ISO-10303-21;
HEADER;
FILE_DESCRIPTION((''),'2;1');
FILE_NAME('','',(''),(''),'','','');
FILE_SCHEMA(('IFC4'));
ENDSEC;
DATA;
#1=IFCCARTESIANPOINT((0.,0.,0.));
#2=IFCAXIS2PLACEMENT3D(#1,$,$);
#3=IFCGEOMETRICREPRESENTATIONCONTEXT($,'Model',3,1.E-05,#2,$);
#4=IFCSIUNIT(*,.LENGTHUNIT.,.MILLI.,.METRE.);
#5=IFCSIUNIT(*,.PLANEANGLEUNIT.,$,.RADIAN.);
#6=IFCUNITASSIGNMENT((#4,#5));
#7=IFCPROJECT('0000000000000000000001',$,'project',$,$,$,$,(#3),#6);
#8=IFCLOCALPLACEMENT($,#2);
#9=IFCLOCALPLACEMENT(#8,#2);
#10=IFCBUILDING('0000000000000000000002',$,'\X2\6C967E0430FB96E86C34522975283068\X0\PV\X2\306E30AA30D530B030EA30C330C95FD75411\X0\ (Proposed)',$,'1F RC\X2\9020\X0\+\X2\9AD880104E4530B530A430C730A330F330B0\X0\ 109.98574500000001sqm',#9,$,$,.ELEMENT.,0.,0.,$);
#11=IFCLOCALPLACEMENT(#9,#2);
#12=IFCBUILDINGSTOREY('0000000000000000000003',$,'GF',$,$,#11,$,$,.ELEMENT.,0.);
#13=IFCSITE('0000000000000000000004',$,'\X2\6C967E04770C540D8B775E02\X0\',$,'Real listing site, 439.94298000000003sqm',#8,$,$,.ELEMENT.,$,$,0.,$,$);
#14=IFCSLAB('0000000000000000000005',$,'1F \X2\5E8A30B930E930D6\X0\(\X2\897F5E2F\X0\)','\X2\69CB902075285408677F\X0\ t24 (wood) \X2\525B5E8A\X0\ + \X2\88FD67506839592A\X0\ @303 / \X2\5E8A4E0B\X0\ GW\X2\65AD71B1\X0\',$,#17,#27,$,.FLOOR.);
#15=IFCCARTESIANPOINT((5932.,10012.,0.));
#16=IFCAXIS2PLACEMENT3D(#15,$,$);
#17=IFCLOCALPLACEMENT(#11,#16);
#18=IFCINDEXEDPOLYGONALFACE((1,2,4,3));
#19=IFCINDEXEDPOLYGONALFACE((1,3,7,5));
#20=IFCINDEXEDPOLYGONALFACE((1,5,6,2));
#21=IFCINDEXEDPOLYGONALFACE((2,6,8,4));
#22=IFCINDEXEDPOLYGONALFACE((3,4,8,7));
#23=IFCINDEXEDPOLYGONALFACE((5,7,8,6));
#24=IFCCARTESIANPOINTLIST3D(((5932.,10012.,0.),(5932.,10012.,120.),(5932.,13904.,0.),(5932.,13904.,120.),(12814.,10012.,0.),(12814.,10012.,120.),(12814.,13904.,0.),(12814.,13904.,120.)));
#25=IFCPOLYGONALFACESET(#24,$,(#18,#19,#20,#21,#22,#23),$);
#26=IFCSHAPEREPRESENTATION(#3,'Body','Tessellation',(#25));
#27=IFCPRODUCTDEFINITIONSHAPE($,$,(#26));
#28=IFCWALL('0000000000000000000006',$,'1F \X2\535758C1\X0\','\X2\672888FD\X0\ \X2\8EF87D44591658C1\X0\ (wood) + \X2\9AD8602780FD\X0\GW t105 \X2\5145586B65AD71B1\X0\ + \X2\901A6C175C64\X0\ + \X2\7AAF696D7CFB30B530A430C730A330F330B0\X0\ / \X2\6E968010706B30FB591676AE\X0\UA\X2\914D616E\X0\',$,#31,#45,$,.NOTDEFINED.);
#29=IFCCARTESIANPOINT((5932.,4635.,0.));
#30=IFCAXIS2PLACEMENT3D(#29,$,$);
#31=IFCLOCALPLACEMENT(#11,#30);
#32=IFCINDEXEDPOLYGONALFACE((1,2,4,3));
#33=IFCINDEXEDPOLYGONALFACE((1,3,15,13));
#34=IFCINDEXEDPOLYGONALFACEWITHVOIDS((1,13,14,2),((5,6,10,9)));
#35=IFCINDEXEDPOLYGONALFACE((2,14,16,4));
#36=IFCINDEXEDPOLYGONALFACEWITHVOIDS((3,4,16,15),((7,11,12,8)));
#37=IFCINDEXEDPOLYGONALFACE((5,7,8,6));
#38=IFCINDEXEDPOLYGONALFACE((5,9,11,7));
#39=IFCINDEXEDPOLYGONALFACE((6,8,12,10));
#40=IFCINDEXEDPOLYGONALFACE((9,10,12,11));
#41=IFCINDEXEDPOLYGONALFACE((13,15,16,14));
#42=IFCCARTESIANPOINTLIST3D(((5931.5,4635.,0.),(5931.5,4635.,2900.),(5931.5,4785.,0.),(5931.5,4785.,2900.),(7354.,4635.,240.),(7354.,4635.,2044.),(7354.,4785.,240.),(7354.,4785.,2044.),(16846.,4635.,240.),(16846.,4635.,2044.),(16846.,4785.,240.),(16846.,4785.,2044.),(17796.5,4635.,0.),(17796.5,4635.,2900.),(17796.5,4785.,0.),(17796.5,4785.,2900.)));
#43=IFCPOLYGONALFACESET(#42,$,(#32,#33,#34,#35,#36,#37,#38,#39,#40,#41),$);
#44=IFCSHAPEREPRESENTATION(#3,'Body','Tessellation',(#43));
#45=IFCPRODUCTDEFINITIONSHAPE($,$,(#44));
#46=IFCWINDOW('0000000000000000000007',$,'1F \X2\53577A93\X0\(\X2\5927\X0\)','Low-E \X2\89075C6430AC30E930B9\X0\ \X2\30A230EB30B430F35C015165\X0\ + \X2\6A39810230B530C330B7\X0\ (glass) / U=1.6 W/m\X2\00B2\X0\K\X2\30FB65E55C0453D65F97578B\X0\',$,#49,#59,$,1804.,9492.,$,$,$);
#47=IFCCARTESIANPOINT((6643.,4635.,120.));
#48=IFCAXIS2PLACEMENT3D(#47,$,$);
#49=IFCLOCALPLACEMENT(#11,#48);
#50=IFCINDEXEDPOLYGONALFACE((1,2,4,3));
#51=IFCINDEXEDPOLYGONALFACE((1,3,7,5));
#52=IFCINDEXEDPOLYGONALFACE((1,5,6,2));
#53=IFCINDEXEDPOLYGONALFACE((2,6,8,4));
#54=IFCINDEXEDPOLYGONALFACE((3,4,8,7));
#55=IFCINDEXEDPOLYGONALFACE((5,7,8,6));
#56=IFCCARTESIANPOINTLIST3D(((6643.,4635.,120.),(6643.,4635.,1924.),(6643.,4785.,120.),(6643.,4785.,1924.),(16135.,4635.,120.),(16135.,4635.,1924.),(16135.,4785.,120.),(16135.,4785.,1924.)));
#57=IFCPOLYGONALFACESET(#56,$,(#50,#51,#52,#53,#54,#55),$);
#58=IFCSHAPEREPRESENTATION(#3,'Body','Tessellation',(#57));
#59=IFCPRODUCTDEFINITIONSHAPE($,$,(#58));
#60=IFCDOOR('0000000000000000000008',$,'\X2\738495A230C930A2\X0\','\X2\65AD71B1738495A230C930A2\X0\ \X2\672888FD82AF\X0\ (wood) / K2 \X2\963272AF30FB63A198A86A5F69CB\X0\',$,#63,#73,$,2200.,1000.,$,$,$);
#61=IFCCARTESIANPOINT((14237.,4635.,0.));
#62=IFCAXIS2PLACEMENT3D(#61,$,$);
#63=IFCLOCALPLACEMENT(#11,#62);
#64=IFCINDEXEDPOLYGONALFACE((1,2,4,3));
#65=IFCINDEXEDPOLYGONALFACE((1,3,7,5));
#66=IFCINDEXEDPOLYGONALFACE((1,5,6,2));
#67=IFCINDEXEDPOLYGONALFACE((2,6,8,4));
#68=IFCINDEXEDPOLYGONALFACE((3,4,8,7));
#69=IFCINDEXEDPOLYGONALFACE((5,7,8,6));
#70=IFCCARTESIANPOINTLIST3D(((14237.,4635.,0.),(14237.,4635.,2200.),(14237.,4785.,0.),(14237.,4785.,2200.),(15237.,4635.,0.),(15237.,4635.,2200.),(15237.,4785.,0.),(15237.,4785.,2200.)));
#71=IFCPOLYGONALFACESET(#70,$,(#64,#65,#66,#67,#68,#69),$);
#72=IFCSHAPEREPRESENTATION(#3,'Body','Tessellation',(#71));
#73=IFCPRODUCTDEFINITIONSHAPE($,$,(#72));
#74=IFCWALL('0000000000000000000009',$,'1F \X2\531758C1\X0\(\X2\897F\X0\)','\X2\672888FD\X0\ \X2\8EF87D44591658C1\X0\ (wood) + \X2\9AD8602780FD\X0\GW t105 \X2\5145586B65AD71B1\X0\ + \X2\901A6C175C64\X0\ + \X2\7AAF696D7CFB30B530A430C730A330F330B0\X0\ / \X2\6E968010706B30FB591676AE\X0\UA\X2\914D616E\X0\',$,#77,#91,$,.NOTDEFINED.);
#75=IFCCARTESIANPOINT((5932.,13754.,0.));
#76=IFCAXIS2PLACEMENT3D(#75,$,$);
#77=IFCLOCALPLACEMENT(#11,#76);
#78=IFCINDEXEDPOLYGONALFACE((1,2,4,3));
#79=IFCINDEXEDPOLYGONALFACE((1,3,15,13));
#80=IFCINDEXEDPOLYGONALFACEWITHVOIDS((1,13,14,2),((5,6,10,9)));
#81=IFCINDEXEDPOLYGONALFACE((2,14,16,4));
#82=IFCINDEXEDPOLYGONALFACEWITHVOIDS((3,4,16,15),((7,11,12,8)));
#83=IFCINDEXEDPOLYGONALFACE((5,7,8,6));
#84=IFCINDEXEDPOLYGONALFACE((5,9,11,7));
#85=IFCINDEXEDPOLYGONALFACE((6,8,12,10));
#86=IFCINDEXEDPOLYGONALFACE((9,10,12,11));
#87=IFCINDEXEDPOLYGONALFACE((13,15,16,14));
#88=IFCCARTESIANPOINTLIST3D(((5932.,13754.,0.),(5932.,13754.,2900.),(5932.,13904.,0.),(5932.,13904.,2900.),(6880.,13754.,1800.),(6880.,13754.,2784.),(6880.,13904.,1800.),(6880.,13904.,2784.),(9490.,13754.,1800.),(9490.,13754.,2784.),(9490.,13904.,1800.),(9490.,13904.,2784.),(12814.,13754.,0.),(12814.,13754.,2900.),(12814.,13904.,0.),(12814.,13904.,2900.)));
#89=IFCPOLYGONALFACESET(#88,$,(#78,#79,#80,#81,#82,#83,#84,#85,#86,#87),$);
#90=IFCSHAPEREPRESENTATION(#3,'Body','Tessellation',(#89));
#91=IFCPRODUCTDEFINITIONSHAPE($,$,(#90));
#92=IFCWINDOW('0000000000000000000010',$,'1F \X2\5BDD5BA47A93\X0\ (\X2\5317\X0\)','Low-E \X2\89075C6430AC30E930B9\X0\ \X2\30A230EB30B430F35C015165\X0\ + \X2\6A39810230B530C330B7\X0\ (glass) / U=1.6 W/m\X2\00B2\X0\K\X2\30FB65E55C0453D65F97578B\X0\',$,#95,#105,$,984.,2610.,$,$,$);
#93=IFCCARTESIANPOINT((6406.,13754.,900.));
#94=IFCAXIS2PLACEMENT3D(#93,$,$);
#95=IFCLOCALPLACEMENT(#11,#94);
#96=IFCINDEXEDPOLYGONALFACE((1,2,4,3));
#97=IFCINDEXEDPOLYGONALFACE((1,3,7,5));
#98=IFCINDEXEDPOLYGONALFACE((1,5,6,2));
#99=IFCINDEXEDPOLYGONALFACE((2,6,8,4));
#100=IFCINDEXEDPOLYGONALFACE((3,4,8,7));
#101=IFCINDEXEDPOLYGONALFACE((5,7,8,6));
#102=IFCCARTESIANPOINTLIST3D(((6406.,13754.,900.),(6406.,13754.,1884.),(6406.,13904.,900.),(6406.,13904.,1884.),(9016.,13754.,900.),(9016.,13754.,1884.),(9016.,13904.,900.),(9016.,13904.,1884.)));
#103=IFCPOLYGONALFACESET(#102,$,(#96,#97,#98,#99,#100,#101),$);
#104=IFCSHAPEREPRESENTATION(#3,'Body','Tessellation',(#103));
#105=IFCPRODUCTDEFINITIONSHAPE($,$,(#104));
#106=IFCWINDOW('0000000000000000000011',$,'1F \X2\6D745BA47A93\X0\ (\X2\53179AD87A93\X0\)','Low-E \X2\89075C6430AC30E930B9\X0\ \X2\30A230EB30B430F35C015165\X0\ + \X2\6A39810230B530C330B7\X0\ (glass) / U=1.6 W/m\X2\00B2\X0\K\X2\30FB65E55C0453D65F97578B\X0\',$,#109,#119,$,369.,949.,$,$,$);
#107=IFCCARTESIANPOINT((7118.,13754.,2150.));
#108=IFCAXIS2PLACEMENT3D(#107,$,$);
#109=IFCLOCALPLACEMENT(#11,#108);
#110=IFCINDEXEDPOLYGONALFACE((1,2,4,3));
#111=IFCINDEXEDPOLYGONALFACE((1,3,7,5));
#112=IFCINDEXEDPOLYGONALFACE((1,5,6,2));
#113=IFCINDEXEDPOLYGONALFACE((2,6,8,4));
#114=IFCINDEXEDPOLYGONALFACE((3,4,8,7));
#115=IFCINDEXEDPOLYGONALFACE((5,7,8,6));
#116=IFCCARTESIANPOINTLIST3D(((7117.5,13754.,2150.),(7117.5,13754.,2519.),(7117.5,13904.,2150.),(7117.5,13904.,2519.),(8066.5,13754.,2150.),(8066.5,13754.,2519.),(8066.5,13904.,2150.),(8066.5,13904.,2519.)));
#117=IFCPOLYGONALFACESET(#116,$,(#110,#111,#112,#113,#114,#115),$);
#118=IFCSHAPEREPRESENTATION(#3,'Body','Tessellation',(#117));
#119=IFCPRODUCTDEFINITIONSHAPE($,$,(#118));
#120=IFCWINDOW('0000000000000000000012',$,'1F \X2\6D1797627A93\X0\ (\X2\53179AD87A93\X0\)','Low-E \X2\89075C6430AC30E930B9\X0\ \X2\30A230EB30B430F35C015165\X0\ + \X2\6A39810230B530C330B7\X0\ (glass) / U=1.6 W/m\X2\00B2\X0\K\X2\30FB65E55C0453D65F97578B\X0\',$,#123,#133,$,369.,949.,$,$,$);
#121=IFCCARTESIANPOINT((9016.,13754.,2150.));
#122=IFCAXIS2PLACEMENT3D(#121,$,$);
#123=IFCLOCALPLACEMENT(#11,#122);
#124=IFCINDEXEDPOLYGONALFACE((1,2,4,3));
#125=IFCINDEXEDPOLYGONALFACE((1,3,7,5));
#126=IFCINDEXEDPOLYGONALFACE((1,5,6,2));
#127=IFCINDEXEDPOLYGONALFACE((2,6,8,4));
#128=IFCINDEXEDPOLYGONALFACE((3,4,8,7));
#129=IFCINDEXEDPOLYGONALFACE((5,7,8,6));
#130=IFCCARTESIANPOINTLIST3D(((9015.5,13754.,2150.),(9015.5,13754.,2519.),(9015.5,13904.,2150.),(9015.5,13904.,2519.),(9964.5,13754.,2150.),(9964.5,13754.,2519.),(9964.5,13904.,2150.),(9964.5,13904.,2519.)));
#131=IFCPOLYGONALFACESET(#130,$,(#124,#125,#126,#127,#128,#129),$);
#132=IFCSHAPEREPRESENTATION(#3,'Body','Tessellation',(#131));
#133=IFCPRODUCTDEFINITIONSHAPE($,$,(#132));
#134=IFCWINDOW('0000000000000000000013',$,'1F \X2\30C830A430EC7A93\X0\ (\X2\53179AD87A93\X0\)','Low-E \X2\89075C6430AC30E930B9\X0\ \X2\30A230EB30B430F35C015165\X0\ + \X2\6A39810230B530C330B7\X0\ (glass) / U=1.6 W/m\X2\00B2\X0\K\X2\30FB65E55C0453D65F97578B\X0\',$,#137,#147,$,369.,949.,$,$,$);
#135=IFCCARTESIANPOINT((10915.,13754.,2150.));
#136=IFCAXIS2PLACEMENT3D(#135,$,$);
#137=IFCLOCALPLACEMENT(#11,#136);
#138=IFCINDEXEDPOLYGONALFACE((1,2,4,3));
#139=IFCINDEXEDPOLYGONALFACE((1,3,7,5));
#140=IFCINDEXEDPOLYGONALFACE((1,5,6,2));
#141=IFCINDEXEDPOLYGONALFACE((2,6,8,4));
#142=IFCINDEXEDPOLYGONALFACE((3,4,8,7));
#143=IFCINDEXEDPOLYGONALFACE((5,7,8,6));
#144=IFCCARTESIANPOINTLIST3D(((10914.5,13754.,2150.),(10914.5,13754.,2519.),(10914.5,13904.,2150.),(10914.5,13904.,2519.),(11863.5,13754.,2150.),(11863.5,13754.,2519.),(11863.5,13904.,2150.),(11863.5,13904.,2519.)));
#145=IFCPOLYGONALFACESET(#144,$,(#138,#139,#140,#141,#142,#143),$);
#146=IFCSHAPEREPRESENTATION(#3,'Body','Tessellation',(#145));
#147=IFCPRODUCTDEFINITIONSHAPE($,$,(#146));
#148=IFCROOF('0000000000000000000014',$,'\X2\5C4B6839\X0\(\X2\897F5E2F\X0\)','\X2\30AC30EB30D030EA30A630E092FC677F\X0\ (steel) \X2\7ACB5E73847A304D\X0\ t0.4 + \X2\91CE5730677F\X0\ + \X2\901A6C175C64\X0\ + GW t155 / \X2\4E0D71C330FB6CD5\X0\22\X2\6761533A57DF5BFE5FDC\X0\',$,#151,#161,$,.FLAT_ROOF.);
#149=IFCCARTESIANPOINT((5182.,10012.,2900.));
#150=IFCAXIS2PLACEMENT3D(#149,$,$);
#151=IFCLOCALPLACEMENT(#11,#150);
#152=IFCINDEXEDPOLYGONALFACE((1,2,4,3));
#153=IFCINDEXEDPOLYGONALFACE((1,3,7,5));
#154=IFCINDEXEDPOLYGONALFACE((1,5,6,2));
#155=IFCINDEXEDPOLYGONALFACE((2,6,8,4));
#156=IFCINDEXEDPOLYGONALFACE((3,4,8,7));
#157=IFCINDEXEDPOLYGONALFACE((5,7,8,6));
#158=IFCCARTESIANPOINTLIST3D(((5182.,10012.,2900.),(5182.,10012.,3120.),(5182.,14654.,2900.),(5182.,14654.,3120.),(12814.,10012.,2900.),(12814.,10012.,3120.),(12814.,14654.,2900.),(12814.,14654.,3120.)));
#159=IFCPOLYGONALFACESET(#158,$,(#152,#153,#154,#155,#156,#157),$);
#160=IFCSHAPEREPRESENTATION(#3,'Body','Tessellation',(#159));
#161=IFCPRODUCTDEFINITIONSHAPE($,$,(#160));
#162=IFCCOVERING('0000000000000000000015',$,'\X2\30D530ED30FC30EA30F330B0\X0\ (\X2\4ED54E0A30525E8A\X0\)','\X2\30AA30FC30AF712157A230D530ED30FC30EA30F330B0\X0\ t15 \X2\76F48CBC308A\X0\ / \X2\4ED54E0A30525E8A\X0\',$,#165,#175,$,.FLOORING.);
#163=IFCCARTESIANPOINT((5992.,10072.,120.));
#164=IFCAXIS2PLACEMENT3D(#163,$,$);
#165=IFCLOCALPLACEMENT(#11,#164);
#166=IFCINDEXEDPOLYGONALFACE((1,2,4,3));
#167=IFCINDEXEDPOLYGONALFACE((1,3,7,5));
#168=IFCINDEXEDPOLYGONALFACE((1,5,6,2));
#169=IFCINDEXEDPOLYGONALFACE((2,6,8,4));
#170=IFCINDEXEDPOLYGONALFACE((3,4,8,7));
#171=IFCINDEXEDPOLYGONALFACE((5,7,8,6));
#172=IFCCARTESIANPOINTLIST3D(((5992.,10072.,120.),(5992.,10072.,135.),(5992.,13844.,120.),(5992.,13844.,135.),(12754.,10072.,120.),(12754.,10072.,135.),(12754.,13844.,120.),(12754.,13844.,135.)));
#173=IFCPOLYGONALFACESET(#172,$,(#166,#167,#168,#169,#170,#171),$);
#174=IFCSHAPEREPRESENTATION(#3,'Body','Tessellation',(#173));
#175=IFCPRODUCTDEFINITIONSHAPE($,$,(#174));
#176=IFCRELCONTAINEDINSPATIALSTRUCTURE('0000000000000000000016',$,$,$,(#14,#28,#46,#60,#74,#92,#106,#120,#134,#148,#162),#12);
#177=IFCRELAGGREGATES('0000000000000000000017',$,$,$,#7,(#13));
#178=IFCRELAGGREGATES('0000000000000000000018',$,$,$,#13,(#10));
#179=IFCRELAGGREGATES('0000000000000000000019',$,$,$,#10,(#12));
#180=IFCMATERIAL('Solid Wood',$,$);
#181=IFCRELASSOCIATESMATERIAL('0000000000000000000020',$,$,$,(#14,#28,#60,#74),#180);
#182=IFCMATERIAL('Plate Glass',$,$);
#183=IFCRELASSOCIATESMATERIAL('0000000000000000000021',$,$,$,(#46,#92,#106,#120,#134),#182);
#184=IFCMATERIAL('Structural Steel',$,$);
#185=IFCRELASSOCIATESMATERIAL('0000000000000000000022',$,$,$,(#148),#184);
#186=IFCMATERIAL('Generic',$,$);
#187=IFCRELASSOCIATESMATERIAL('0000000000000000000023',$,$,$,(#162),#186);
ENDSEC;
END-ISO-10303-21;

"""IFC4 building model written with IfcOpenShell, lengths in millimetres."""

from ifc_helpers import new_model, si_unit, frame, frame_2d, origin, place, context, project, spatial, rectangle, extrude, material, element, fill, save


model = new_model("IFC4")

# Units and contexts
model_context = context("Model", 3, precision=1e-05, world=origin())
ifc_project = project(units=[si_unit("LENGTHUNIT", "METRE", prefix="MILLI"), si_unit("PLANEANGLEUNIT", "RADIAN")], contexts=[model_context])

# Site, building, storey
site_placement = place(None, origin())
site = spatial("IfcSite", under=ifc_project, at=site_placement, Name="沖縄県名護市", ObjectType="Real listing site, 439.94298000000003sqm", CompositionType="ELEMENT", RefElevation=0.0)
building_placement = place(site_placement, origin())
building = spatial("IfcBuilding", under=site, at=building_placement, Name="沖縄・雨水利用とPVのオフグリッド志向 (Proposed)", ObjectType="1F RC造+高耐久サイディング 109.98574500000001sqm", CompositionType="ELEMENT", ElevationOfRefHeight=0.0, ElevationOfTerrain=0.0)
storey_placement = place(building_placement, origin())
storey = spatial("IfcBuildingStorey", under=building, at=storey_placement, Name="GF", CompositionType="ELEMENT", Elevation=0.0)

# Slab
ifc_material_1 = material(Name="Solid Wood")
slab_1_placement = place(storey_placement, frame((5932.0, 10012.0, 0.0)))
element("IfcSlab", 1, at=slab_1_placement, inside=storey, material=ifc_material_1, Name="1F 床スラブ(西帯)", Description="構造用合板 t24 (wood) 剛床 + 製材根太 @303 / 床下 GW断熱", PredefinedType="FLOOR", context=model_context, shape_type="SweptSolid", body=[
    extrude(rectangle(XDim=6882.0, YDim=3892.0, at=frame_2d((3441.0, 1946.0))), frame((5932.0, 10012.0, 0.0)), (0.0, 0.0, 1.0), 120.0),
])

# Wall, openings, window, door
wall_1_placement = place(storey_placement, frame((5932.0, 4635.0, 0.0)))
wall_1 = element("IfcWall", 2, at=wall_1_placement, inside=storey, material=ifc_material_1, Name="1F 南壁", Description="木製 軸組外壁 (wood) + 高性能GW t105 充填断熱 + 通気層 + 窯業系サイディング / 準耐火・外皮UA配慮", PredefinedType="NOTDEFINED", context=model_context, shape_type="SweptSolid", body=[
    extrude(rectangle(XDim=11865.0, YDim=150.0, at=frame_2d((5932.0, 75.0))), frame((5932.0, 4635.0, 0.0)), (0.0, 0.0, 1.0), 2900.0),
])
opening_1_placement = place(storey_placement, frame((6643.0, 4635.0, 120.0)))
opening_1 = element("IfcOpeningElement", 3, at=opening_1_placement, cuts=wall_1, PredefinedType="NOTDEFINED", context=model_context, shape_type="SweptSolid", body=[
    extrude(rectangle(XDim=9492.0, YDim=150.0, at=frame_2d((4746.0, 75.0))), frame((6643.0, 4635.0, 120.0)), (0.0, 0.0, 1.0), 1804.0),
])
opening_2_placement = place(storey_placement, frame((14237.0, 4635.0, 0.0)))
opening_2 = element("IfcOpeningElement", 4, at=opening_2_placement, cuts=wall_1, PredefinedType="NOTDEFINED", context=model_context, shape_type="SweptSolid", body=[
    extrude(rectangle(XDim=1000.0, YDim=150.0, at=frame_2d((500.0, 75.0))), frame((14237.0, 4635.0, 0.0)), (0.0, 0.0, 1.0), 2200.0),
])
ifc_material_2 = material(Name="Plate Glass")
window_1_placement = place(storey_placement, frame((6643.0, 4635.0, 120.0)))
window_1 = element("IfcWindow", 5, at=window_1_placement, inside=storey, material=ifc_material_2, Name="1F 南窓(大)", Description="Low-E 複層ガラス アルゴン封入 + 樹脂サッシ (glass) / U=1.6 W/m²K・日射取得型", OverallHeight=1804.0, OverallWidth=9492.0, context=model_context, shape_type="SweptSolid", body=[
    extrude(rectangle(XDim=9492.0, YDim=150.0, at=frame_2d((4746.0, 75.0))), frame((6643.0, 4635.0, 120.0)), (0.0, 0.0, 1.0), 1804.0),
])
fill(opening_1, window_1)
door_1_placement = place(storey_placement, frame((14237.0, 4635.0, 0.0)))
door_1 = element("IfcDoor", 6, at=door_1_placement, inside=storey, material=ifc_material_1, Name="玄関ドア", Description="断熱玄関ドア 木製芯 (wood) / K2 防犯・採風機構", OverallHeight=2200.0, OverallWidth=1000.0, context=model_context, shape_type="SweptSolid", body=[
    extrude(rectangle(XDim=1000.0, YDim=150.0, at=frame_2d((500.0, 75.0))), frame((14237.0, 4635.0, 0.0)), (0.0, 0.0, 1.0), 2200.0),
])
fill(opening_2, door_1)

# Wall, openings, windows
wall_2_placement = place(storey_placement, frame((5932.0, 13754.0, 0.0)))
wall_2 = element("IfcWall", 7, at=wall_2_placement, inside=storey, material=ifc_material_1, Name="1F 北壁(西)", Description="木製 軸組外壁 (wood) + 高性能GW t105 充填断熱 + 通気層 + 窯業系サイディング / 準耐火・外皮UA配慮", PredefinedType="NOTDEFINED", context=model_context, shape_type="SweptSolid", body=[
    extrude(rectangle(XDim=6882.0, YDim=150.0, at=frame_2d((3441.0, 75.0))), frame((5932.0, 13754.0, 0.0)), (0.0, 0.0, 1.0), 2900.0),
])
opening_3_placement = place(storey_placement, frame((6406.0, 13754.0, 900.0)))
opening_3 = element("IfcOpeningElement", 8, at=opening_3_placement, cuts=wall_2, PredefinedType="NOTDEFINED", context=model_context, shape_type="SweptSolid", body=[
    extrude(rectangle(XDim=2610.0, YDim=150.0, at=frame_2d((1305.0, 75.0))), frame((6406.0, 13754.0, 900.0)), (0.0, 0.0, 1.0), 984.0),
])
opening_4_placement = place(storey_placement, frame((7118.0, 13754.0, 2150.0)))
opening_4 = element("IfcOpeningElement", 9, at=opening_4_placement, cuts=wall_2, PredefinedType="NOTDEFINED", context=model_context, shape_type="SweptSolid", body=[
    extrude(rectangle(XDim=949.0, YDim=150.0, at=frame_2d((474.0, 75.0))), frame((7118.0, 13754.0, 2150.0)), (0.0, 0.0, 1.0), 369.0),
])
opening_5_placement = place(storey_placement, frame((9016.0, 13754.0, 2150.0)))
opening_5 = element("IfcOpeningElement", 10, at=opening_5_placement, cuts=wall_2, PredefinedType="NOTDEFINED", context=model_context, shape_type="SweptSolid", body=[
    extrude(rectangle(XDim=949.0, YDim=150.0, at=frame_2d((474.0, 75.0))), frame((9016.0, 13754.0, 2150.0)), (0.0, 0.0, 1.0), 369.0),
])
opening_6_placement = place(storey_placement, frame((10915.0, 13754.0, 2150.0)))
opening_6 = element("IfcOpeningElement", 11, at=opening_6_placement, cuts=wall_2, PredefinedType="NOTDEFINED", context=model_context, shape_type="SweptSolid", body=[
    extrude(rectangle(XDim=949.0, YDim=150.0, at=frame_2d((474.0, 75.0))), frame((10915.0, 13754.0, 2150.0)), (0.0, 0.0, 1.0), 369.0),
])
window_2_placement = place(storey_placement, frame((6406.0, 13754.0, 900.0)))
window_2 = element("IfcWindow", 12, at=window_2_placement, inside=storey, material=ifc_material_2, Name="1F 寝室窓 (北)", Description="Low-E 複層ガラス アルゴン封入 + 樹脂サッシ (glass) / U=1.6 W/m²K・日射取得型", OverallHeight=984.0, OverallWidth=2610.0, context=model_context, shape_type="SweptSolid", body=[
    extrude(rectangle(XDim=2610.0, YDim=150.0, at=frame_2d((1305.0, 75.0))), frame((6406.0, 13754.0, 900.0)), (0.0, 0.0, 1.0), 984.0),
])
fill(opening_3, window_2)
window_3_placement = place(storey_placement, frame((7118.0, 13754.0, 2150.0)))
window_3 = element("IfcWindow", 13, at=window_3_placement, inside=storey, material=ifc_material_2, Name="1F 浴室窓 (北高窓)", Description="Low-E 複層ガラス アルゴン封入 + 樹脂サッシ (glass) / U=1.6 W/m²K・日射取得型", OverallHeight=369.0, OverallWidth=949.0, context=model_context, shape_type="SweptSolid", body=[
    extrude(rectangle(XDim=949.0, YDim=150.0, at=frame_2d((474.0, 75.0))), frame((7118.0, 13754.0, 2150.0)), (0.0, 0.0, 1.0), 369.0),
])
fill(opening_4, window_3)
window_4_placement = place(storey_placement, frame((9016.0, 13754.0, 2150.0)))
window_4 = element("IfcWindow", 14, at=window_4_placement, inside=storey, material=ifc_material_2, Name="1F 洗面窓 (北高窓)", Description="Low-E 複層ガラス アルゴン封入 + 樹脂サッシ (glass) / U=1.6 W/m²K・日射取得型", OverallHeight=369.0, OverallWidth=949.0, context=model_context, shape_type="SweptSolid", body=[
    extrude(rectangle(XDim=949.0, YDim=150.0, at=frame_2d((474.0, 75.0))), frame((9016.0, 13754.0, 2150.0)), (0.0, 0.0, 1.0), 369.0),
])
fill(opening_5, window_4)
window_5_placement = place(storey_placement, frame((10915.0, 13754.0, 2150.0)))
window_5 = element("IfcWindow", 15, at=window_5_placement, inside=storey, material=ifc_material_2, Name="1F トイレ窓 (北高窓)", Description="Low-E 複層ガラス アルゴン封入 + 樹脂サッシ (glass) / U=1.6 W/m²K・日射取得型", OverallHeight=369.0, OverallWidth=949.0, context=model_context, shape_type="SweptSolid", body=[
    extrude(rectangle(XDim=949.0, YDim=150.0, at=frame_2d((474.0, 75.0))), frame((10915.0, 13754.0, 2150.0)), (0.0, 0.0, 1.0), 369.0),
])
fill(opening_6, window_5)

# Roof
ifc_material_3 = material(Name="Structural Steel")
roof_1_placement = place(storey_placement, frame((5182.0, 10012.0, 2900.0)))
element("IfcRoof", 16, at=roof_1_placement, inside=storey, material=ifc_material_3, Name="屋根(西帯)", Description="ガルバリウム鋼板 (steel) 立平葺き t0.4 + 野地板 + 通気層 + GW t155 / 不燃・法22条区域対応", PredefinedType="FLAT_ROOF", context=model_context, shape_type="SweptSolid", body=[
    extrude(rectangle(XDim=7632.0, YDim=4642.0, at=frame_2d((3816.0, 2321.0))), frame((5182.0, 10012.0, 2900.0)), (0.0, 0.0, 1.0), 220.0),
])

# Covering
ifc_material_4 = material(Name="Generic")
covering_1_placement = place(storey_placement, frame((5992.0, 10072.0, 120.0)))
element("IfcCovering", 17, at=covering_1_placement, inside=storey, material=ifc_material_4, Name="フローリング (仕上げ床)", Description="オーク無垢フローリング t15 直貼り / 仕上げ床", PredefinedType="FLOORING", context=model_context, shape_type="SweptSolid", body=[
    extrude(rectangle(XDim=6762.0, YDim=3772.0, at=frame_2d((3381.0, 1886.0))), frame((5992.0, 10072.0, 120.0)), (0.0, 0.0, 1.0), 15.0),
])

save(model, "model.ifc")
